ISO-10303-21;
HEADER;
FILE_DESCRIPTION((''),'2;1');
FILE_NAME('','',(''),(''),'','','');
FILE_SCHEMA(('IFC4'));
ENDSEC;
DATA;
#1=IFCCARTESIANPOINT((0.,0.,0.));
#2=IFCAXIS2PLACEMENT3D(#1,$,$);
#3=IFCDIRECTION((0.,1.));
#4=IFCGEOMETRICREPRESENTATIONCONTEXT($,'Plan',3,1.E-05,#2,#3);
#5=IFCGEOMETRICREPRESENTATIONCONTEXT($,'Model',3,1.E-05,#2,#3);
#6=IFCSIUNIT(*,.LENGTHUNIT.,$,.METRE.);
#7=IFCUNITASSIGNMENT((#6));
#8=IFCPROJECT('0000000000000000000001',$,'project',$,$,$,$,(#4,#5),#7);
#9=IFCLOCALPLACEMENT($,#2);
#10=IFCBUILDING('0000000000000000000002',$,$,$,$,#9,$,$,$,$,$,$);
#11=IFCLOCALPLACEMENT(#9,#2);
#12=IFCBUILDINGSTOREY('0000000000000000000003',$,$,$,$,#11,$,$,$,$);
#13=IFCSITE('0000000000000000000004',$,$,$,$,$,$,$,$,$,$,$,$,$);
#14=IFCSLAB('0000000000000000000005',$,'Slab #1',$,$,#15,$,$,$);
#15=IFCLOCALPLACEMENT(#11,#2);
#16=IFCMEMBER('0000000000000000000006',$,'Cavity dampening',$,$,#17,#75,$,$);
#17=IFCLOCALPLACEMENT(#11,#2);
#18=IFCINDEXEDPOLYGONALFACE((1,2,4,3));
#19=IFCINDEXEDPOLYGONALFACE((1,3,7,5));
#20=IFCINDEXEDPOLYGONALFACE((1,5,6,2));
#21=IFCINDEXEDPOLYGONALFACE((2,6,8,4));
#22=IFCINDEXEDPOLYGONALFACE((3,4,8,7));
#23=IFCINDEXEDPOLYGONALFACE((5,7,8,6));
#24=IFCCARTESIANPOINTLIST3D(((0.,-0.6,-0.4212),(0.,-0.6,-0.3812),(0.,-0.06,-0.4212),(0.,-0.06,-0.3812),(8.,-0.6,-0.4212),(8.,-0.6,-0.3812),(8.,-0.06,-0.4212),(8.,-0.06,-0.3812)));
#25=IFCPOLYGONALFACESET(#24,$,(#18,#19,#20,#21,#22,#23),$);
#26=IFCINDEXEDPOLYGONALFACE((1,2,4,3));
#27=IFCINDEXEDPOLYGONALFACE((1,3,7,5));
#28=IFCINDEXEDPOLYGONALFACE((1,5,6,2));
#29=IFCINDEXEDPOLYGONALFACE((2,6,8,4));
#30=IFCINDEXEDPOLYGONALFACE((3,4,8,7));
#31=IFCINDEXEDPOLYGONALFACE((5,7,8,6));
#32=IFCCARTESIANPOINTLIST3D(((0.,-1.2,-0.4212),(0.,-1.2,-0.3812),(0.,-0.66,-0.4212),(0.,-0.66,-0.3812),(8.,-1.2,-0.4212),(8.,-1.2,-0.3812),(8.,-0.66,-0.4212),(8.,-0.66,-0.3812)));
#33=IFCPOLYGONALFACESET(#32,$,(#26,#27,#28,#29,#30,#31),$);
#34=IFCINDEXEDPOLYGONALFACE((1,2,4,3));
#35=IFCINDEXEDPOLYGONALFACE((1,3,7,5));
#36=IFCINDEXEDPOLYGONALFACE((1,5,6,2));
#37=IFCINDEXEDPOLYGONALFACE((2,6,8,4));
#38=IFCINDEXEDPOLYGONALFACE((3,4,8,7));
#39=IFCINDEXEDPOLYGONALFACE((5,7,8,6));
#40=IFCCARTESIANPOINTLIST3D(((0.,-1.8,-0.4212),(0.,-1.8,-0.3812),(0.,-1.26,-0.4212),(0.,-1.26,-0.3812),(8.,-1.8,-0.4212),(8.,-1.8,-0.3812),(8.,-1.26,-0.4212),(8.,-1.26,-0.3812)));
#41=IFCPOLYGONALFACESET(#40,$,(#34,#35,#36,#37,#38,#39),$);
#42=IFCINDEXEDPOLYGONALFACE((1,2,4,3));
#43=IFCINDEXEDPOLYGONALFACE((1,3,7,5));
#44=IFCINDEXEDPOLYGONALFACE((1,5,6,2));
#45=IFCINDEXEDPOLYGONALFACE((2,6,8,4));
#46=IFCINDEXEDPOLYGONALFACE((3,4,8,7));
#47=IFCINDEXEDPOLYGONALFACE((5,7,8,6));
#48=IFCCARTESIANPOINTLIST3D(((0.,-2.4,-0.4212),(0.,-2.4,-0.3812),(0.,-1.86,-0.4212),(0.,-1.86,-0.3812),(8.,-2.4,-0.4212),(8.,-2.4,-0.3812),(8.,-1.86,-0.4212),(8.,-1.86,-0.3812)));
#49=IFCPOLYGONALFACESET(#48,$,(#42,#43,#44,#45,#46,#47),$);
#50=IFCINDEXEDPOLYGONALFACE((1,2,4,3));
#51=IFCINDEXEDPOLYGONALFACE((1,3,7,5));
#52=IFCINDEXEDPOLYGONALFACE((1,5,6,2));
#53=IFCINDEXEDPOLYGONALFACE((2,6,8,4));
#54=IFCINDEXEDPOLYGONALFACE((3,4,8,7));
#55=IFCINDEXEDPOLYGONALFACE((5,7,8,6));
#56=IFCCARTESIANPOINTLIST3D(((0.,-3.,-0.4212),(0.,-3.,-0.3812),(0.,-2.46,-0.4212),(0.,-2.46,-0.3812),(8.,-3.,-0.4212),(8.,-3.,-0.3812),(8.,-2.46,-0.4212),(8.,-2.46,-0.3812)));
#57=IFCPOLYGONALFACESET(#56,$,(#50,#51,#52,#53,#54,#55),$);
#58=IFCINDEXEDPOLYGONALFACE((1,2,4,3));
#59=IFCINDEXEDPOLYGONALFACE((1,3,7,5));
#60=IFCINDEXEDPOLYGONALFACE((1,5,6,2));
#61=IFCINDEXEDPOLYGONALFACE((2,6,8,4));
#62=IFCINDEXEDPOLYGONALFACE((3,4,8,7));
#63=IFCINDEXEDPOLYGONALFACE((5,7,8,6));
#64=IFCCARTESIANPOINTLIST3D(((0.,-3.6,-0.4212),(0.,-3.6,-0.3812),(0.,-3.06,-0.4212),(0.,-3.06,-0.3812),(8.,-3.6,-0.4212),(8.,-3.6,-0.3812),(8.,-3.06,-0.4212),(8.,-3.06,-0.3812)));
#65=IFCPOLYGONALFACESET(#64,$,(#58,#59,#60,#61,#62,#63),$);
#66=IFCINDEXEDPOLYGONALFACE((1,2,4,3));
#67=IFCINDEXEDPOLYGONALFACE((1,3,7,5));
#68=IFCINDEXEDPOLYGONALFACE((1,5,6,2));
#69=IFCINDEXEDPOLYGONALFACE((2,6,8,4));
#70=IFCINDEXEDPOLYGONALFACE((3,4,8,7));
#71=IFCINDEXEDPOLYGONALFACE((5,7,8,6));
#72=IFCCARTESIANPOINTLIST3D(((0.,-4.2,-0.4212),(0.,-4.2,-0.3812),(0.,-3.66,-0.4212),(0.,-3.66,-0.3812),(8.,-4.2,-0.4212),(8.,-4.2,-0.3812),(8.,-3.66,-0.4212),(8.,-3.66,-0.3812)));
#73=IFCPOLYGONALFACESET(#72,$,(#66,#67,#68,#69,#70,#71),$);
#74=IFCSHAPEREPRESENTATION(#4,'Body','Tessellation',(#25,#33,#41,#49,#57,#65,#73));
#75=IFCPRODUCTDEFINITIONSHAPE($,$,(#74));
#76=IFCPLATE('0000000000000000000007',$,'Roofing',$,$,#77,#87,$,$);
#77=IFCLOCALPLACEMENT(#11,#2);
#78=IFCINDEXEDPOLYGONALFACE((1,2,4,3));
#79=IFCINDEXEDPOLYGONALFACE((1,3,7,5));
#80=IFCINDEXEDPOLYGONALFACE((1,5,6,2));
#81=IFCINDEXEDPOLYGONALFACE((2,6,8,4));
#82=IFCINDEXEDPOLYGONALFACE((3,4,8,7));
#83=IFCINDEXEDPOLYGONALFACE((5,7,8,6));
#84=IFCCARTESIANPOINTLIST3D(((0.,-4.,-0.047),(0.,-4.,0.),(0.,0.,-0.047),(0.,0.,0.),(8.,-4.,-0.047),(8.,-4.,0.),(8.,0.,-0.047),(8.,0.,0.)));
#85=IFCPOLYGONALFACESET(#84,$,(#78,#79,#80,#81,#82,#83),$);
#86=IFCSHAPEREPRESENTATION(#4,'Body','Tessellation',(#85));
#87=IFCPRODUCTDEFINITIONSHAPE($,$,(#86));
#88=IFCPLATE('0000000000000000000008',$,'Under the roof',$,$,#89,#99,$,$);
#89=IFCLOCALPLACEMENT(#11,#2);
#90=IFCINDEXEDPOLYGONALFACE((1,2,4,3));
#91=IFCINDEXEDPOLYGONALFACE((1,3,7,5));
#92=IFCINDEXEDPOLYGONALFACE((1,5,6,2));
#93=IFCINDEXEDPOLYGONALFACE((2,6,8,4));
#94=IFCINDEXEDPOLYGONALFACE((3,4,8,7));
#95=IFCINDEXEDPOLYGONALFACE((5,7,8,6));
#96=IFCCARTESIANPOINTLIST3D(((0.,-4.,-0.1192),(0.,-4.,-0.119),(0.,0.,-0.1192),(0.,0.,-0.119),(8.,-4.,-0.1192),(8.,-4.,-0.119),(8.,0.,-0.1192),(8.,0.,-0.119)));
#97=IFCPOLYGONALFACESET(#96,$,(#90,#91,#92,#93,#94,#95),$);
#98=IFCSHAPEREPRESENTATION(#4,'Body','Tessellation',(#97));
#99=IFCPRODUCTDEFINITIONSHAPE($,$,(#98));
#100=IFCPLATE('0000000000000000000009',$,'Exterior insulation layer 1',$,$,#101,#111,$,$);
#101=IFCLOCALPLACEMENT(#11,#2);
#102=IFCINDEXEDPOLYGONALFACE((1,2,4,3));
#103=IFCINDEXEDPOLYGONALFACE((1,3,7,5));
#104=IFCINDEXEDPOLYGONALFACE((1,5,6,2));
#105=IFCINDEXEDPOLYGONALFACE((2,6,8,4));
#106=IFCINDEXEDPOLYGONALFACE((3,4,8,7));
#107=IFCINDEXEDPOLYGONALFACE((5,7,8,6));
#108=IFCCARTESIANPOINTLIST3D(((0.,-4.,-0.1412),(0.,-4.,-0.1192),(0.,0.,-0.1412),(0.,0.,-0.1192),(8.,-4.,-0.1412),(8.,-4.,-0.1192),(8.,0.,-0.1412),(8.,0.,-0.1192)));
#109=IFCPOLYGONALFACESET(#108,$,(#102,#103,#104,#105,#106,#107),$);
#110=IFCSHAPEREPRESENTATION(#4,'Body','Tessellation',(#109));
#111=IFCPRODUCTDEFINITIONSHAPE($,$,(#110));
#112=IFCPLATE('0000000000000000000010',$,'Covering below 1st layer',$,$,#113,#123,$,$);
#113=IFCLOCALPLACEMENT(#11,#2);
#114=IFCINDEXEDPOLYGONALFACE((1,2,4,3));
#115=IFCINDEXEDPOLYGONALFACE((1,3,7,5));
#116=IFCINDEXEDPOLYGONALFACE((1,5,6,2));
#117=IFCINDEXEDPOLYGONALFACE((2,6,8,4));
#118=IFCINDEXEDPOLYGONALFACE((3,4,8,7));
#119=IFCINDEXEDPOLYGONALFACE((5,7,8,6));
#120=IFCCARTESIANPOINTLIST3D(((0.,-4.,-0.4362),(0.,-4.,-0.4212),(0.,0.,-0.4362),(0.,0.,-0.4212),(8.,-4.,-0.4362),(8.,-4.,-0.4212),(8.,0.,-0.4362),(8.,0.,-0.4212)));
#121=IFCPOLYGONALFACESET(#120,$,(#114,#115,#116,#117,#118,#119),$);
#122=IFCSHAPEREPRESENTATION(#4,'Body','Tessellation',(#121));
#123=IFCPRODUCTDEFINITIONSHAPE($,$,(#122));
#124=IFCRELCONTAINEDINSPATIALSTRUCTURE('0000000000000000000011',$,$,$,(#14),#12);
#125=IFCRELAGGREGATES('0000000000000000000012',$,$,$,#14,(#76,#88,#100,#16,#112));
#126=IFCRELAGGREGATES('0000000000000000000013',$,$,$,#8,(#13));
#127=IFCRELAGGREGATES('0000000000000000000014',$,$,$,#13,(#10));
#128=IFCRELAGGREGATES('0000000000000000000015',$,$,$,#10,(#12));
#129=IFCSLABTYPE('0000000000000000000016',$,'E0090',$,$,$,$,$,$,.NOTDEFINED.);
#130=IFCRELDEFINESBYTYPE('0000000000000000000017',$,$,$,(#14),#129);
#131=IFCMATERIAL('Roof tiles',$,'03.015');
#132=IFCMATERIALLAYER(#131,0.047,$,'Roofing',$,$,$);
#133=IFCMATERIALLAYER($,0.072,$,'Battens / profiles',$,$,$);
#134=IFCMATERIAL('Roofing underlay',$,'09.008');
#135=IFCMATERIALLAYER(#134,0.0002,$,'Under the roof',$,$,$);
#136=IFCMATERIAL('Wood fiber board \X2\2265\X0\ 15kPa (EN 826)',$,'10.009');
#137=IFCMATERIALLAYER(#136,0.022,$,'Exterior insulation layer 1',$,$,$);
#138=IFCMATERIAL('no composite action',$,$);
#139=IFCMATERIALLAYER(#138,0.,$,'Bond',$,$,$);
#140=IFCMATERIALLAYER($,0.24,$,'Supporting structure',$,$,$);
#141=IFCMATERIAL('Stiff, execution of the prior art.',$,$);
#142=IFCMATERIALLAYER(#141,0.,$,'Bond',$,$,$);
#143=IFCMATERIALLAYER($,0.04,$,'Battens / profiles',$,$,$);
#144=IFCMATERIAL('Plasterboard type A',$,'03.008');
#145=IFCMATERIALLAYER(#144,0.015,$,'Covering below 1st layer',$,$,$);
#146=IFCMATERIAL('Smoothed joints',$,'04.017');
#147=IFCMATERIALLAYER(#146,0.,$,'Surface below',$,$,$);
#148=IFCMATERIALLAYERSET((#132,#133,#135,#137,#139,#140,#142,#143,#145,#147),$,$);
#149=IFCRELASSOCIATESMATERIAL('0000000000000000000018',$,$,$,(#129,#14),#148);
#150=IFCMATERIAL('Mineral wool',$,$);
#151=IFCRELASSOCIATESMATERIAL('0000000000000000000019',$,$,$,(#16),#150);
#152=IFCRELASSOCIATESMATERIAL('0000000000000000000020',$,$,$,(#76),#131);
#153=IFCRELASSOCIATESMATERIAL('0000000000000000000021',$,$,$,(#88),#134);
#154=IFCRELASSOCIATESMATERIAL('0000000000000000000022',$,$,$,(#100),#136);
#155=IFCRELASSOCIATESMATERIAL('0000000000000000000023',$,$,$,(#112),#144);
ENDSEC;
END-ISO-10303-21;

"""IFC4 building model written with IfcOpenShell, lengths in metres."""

from ifc_helpers import new_model, si_unit, direction, frame, frame_2d, origin, origin_with_axes, place, context, project, spatial, rectangle, extrude, material, layer, layer_set, type_object, element, aggregate, save


model = new_model("IFC4")

# Units and contexts
plan_context = context("Plan", 3, precision=1e-05, world=origin(), true_north=direction((0.0, 1.0)))
model_context = context("Model", 3, precision=1e-05, world=origin(), true_north=direction((0.0, 1.0)))
ifc_project = project(units=[si_unit("LENGTHUNIT", "METRE")], contexts=[plan_context, model_context])

# Site, building, storey
site = spatial("IfcSite", under=ifc_project)
building_placement = place(None, origin())
building = spatial("IfcBuilding", under=site, at=building_placement)
storey_placement = place(building_placement, origin())
storey = spatial("IfcBuildingStorey", under=building, at=storey_placement)

# Slab, member, plates
ifc_material_1 = material(Name="Roof tiles", Category="03.015")
ifc_layer_1 = layer(ifc_material_1, 0.047, Name="Roofing")
ifc_layer_2 = layer(None, 0.072, Name="Battens / profiles")
ifc_material_2 = material(Name="Roofing underlay", Category="09.008")
ifc_layer_3 = layer(ifc_material_2, 0.0002, Name="Under the roof")
ifc_material_3 = material(Name="Wood fiber board ≥ 15kPa (EN 826)", Category="10.009")
ifc_layer_4 = layer(ifc_material_3, 0.022, Name="Exterior insulation layer 1")
ifc_material_4 = material(Name="no composite action")
ifc_layer_5 = layer(ifc_material_4, 0.0, Name="Bond")
ifc_layer_6 = layer(None, 0.24, Name="Supporting structure")
ifc_material_5 = material(Name="Stiff, execution of the prior art.")
ifc_layer_7 = layer(ifc_material_5, 0.0, Name="Bond")
ifc_layer_8 = layer(None, 0.04, Name="Battens / profiles")
ifc_material_6 = material(Name="Plasterboard type A", Category="03.008")
ifc_layer_9 = layer(ifc_material_6, 0.015, Name="Covering below 1st layer")
ifc_material_7 = material(Name="Smoothed joints", Category="04.017")
ifc_layer_10 = layer(ifc_material_7, 0.0, Name="Surface below")
ifc_layer_set = layer_set([ifc_layer_1, ifc_layer_2, ifc_layer_3, ifc_layer_4, ifc_layer_5, ifc_layer_6, ifc_layer_7, ifc_layer_8, ifc_layer_9, ifc_layer_10])
slab_type = type_object("IfcSlabType", Name="E0090", PredefinedType="NOTDEFINED", material=ifc_layer_set)
slab_placement = place(None, frame((0.0, 0.0, 0.0), z_axis=(0.0, 0.0, -1.0), x_axis=(1.0, 0.0, 0.0)))
slab = element("IfcSlab", 1, at=slab_placement, inside=storey, type_object=slab_type, material=ifc_layer_set, Name="Slab #1")
ifc_material_8 = material(Name="Mineral wool")
member_1_placement = place(slab_placement, origin())
member_1 = element("IfcMember", 2, at=member_1_placement, material=ifc_material_8, Name="Cavity dampening", context=plan_context, shape_type="SweptSolid", body=[
    extrude(rectangle(XDim=0.54, YDim=0.04, at=frame_2d((0.27, 0.02), x_axis=(1.0, 0.0))), frame((0.0, 0.06, 0.3812), z_axis=(1.0, 0.0, 0.0), x_axis=(0.0, 1.0, 0.0)), (0.0, 0.0, 1.0), 8.0),
    extrude(rectangle(XDim=0.54, YDim=0.04, at=frame_2d((0.27, 0.02), x_axis=(1.0, 0.0))), frame((0.0, 0.66, 0.3812), z_axis=(1.0, 0.0, 0.0), x_axis=(0.0, 1.0, 0.0)), (0.0, 0.0, 1.0), 8.0),
    extrude(rectangle(XDim=0.54, YDim=0.04, at=frame_2d((0.27, 0.02), x_axis=(1.0, 0.0))), frame((0.0, 1.26, 0.3812), z_axis=(1.0, 0.0, 0.0), x_axis=(0.0, 1.0, 0.0)), (0.0, 0.0, 1.0), 8.0),
    extrude(rectangle(XDim=0.54, YDim=0.04, at=frame_2d((0.27, 0.02), x_axis=(1.0, 0.0))), frame((0.0, 1.86, 0.3812), z_axis=(1.0, 0.0, 0.0), x_axis=(0.0, 1.0, 0.0)), (0.0, 0.0, 1.0), 8.0),
    extrude(rectangle(XDim=0.54, YDim=0.04, at=frame_2d((0.27, 0.02), x_axis=(1.0, 0.0))), frame((0.0, 2.46, 0.3812), z_axis=(1.0, 0.0, 0.0), x_axis=(0.0, 1.0, 0.0)), (0.0, 0.0, 1.0), 8.0),
    extrude(rectangle(XDim=0.54, YDim=0.04, at=frame_2d((0.27, 0.02), x_axis=(1.0, 0.0))), frame((0.0, 3.06, 0.3812), z_axis=(1.0, 0.0, 0.0), x_axis=(0.0, 1.0, 0.0)), (0.0, 0.0, 1.0), 8.0),
    extrude(rectangle(XDim=0.54, YDim=0.04, at=frame_2d((0.27, 0.02), x_axis=(1.0, 0.0))), frame((0.0, 3.66, 0.3812), z_axis=(1.0, 0.0, 0.0), x_axis=(0.0, 1.0, 0.0)), (0.0, 0.0, 1.0), 8.0),
])
plate_1_placement = place(slab_placement, origin())
plate_1 = element("IfcPlate", 3, at=plate_1_placement, material=ifc_material_1, Name="Roofing", context=plan_context, shape_type="SweptSolid", body=[
    extrude(rectangle(XDim=8.0, YDim=4.0, at=frame_2d((4.0, 2.0), x_axis=(1.0, 0.0))), origin_with_axes(), (0.0, 0.0, 1.0), 0.047),
])
plate_2_placement = place(slab_placement, origin())
plate_2 = element("IfcPlate", 4, at=plate_2_placement, material=ifc_material_2, Name="Under the roof", context=plan_context, shape_type="SweptSolid", body=[
    extrude(rectangle(XDim=8.0, YDim=4.0, at=frame_2d((4.0, 2.0), x_axis=(1.0, 0.0))), frame((0.0, 0.0, 0.119), z_axis=(0.0, 0.0, 1.0), x_axis=(1.0, 0.0, 0.0)), (0.0, 0.0, 1.0), 0.0002),
])
plate_3_placement = place(slab_placement, origin())
plate_3 = element("IfcPlate", 5, at=plate_3_placement, material=ifc_material_3, Name="Exterior insulation layer 1", context=plan_context, shape_type="SweptSolid", body=[
    extrude(rectangle(XDim=8.0, YDim=4.0, at=frame_2d((4.0, 2.0), x_axis=(1.0, 0.0))), frame((0.0, 0.0, 0.1192), z_axis=(0.0, 0.0, 1.0), x_axis=(1.0, 0.0, 0.0)), (0.0, 0.0, 1.0), 0.022),
])
plate_4_placement = place(slab_placement, origin())
plate_4 = element("IfcPlate", 6, at=plate_4_placement, material=ifc_material_6, Name="Covering below 1st layer", context=plan_context, shape_type="SweptSolid", body=[
    extrude(rectangle(XDim=8.0, YDim=4.0, at=frame_2d((4.0, 2.0), x_axis=(1.0, 0.0))), frame((0.0, 0.0, 0.4212), z_axis=(0.0, 0.0, 1.0), x_axis=(1.0, 0.0, 0.0)), (0.0, 0.0, 1.0), 0.015),
])
aggregate(slab, [plate_1, plate_2, plate_3, member_1, plate_4])

save(model, "model.ifc")
